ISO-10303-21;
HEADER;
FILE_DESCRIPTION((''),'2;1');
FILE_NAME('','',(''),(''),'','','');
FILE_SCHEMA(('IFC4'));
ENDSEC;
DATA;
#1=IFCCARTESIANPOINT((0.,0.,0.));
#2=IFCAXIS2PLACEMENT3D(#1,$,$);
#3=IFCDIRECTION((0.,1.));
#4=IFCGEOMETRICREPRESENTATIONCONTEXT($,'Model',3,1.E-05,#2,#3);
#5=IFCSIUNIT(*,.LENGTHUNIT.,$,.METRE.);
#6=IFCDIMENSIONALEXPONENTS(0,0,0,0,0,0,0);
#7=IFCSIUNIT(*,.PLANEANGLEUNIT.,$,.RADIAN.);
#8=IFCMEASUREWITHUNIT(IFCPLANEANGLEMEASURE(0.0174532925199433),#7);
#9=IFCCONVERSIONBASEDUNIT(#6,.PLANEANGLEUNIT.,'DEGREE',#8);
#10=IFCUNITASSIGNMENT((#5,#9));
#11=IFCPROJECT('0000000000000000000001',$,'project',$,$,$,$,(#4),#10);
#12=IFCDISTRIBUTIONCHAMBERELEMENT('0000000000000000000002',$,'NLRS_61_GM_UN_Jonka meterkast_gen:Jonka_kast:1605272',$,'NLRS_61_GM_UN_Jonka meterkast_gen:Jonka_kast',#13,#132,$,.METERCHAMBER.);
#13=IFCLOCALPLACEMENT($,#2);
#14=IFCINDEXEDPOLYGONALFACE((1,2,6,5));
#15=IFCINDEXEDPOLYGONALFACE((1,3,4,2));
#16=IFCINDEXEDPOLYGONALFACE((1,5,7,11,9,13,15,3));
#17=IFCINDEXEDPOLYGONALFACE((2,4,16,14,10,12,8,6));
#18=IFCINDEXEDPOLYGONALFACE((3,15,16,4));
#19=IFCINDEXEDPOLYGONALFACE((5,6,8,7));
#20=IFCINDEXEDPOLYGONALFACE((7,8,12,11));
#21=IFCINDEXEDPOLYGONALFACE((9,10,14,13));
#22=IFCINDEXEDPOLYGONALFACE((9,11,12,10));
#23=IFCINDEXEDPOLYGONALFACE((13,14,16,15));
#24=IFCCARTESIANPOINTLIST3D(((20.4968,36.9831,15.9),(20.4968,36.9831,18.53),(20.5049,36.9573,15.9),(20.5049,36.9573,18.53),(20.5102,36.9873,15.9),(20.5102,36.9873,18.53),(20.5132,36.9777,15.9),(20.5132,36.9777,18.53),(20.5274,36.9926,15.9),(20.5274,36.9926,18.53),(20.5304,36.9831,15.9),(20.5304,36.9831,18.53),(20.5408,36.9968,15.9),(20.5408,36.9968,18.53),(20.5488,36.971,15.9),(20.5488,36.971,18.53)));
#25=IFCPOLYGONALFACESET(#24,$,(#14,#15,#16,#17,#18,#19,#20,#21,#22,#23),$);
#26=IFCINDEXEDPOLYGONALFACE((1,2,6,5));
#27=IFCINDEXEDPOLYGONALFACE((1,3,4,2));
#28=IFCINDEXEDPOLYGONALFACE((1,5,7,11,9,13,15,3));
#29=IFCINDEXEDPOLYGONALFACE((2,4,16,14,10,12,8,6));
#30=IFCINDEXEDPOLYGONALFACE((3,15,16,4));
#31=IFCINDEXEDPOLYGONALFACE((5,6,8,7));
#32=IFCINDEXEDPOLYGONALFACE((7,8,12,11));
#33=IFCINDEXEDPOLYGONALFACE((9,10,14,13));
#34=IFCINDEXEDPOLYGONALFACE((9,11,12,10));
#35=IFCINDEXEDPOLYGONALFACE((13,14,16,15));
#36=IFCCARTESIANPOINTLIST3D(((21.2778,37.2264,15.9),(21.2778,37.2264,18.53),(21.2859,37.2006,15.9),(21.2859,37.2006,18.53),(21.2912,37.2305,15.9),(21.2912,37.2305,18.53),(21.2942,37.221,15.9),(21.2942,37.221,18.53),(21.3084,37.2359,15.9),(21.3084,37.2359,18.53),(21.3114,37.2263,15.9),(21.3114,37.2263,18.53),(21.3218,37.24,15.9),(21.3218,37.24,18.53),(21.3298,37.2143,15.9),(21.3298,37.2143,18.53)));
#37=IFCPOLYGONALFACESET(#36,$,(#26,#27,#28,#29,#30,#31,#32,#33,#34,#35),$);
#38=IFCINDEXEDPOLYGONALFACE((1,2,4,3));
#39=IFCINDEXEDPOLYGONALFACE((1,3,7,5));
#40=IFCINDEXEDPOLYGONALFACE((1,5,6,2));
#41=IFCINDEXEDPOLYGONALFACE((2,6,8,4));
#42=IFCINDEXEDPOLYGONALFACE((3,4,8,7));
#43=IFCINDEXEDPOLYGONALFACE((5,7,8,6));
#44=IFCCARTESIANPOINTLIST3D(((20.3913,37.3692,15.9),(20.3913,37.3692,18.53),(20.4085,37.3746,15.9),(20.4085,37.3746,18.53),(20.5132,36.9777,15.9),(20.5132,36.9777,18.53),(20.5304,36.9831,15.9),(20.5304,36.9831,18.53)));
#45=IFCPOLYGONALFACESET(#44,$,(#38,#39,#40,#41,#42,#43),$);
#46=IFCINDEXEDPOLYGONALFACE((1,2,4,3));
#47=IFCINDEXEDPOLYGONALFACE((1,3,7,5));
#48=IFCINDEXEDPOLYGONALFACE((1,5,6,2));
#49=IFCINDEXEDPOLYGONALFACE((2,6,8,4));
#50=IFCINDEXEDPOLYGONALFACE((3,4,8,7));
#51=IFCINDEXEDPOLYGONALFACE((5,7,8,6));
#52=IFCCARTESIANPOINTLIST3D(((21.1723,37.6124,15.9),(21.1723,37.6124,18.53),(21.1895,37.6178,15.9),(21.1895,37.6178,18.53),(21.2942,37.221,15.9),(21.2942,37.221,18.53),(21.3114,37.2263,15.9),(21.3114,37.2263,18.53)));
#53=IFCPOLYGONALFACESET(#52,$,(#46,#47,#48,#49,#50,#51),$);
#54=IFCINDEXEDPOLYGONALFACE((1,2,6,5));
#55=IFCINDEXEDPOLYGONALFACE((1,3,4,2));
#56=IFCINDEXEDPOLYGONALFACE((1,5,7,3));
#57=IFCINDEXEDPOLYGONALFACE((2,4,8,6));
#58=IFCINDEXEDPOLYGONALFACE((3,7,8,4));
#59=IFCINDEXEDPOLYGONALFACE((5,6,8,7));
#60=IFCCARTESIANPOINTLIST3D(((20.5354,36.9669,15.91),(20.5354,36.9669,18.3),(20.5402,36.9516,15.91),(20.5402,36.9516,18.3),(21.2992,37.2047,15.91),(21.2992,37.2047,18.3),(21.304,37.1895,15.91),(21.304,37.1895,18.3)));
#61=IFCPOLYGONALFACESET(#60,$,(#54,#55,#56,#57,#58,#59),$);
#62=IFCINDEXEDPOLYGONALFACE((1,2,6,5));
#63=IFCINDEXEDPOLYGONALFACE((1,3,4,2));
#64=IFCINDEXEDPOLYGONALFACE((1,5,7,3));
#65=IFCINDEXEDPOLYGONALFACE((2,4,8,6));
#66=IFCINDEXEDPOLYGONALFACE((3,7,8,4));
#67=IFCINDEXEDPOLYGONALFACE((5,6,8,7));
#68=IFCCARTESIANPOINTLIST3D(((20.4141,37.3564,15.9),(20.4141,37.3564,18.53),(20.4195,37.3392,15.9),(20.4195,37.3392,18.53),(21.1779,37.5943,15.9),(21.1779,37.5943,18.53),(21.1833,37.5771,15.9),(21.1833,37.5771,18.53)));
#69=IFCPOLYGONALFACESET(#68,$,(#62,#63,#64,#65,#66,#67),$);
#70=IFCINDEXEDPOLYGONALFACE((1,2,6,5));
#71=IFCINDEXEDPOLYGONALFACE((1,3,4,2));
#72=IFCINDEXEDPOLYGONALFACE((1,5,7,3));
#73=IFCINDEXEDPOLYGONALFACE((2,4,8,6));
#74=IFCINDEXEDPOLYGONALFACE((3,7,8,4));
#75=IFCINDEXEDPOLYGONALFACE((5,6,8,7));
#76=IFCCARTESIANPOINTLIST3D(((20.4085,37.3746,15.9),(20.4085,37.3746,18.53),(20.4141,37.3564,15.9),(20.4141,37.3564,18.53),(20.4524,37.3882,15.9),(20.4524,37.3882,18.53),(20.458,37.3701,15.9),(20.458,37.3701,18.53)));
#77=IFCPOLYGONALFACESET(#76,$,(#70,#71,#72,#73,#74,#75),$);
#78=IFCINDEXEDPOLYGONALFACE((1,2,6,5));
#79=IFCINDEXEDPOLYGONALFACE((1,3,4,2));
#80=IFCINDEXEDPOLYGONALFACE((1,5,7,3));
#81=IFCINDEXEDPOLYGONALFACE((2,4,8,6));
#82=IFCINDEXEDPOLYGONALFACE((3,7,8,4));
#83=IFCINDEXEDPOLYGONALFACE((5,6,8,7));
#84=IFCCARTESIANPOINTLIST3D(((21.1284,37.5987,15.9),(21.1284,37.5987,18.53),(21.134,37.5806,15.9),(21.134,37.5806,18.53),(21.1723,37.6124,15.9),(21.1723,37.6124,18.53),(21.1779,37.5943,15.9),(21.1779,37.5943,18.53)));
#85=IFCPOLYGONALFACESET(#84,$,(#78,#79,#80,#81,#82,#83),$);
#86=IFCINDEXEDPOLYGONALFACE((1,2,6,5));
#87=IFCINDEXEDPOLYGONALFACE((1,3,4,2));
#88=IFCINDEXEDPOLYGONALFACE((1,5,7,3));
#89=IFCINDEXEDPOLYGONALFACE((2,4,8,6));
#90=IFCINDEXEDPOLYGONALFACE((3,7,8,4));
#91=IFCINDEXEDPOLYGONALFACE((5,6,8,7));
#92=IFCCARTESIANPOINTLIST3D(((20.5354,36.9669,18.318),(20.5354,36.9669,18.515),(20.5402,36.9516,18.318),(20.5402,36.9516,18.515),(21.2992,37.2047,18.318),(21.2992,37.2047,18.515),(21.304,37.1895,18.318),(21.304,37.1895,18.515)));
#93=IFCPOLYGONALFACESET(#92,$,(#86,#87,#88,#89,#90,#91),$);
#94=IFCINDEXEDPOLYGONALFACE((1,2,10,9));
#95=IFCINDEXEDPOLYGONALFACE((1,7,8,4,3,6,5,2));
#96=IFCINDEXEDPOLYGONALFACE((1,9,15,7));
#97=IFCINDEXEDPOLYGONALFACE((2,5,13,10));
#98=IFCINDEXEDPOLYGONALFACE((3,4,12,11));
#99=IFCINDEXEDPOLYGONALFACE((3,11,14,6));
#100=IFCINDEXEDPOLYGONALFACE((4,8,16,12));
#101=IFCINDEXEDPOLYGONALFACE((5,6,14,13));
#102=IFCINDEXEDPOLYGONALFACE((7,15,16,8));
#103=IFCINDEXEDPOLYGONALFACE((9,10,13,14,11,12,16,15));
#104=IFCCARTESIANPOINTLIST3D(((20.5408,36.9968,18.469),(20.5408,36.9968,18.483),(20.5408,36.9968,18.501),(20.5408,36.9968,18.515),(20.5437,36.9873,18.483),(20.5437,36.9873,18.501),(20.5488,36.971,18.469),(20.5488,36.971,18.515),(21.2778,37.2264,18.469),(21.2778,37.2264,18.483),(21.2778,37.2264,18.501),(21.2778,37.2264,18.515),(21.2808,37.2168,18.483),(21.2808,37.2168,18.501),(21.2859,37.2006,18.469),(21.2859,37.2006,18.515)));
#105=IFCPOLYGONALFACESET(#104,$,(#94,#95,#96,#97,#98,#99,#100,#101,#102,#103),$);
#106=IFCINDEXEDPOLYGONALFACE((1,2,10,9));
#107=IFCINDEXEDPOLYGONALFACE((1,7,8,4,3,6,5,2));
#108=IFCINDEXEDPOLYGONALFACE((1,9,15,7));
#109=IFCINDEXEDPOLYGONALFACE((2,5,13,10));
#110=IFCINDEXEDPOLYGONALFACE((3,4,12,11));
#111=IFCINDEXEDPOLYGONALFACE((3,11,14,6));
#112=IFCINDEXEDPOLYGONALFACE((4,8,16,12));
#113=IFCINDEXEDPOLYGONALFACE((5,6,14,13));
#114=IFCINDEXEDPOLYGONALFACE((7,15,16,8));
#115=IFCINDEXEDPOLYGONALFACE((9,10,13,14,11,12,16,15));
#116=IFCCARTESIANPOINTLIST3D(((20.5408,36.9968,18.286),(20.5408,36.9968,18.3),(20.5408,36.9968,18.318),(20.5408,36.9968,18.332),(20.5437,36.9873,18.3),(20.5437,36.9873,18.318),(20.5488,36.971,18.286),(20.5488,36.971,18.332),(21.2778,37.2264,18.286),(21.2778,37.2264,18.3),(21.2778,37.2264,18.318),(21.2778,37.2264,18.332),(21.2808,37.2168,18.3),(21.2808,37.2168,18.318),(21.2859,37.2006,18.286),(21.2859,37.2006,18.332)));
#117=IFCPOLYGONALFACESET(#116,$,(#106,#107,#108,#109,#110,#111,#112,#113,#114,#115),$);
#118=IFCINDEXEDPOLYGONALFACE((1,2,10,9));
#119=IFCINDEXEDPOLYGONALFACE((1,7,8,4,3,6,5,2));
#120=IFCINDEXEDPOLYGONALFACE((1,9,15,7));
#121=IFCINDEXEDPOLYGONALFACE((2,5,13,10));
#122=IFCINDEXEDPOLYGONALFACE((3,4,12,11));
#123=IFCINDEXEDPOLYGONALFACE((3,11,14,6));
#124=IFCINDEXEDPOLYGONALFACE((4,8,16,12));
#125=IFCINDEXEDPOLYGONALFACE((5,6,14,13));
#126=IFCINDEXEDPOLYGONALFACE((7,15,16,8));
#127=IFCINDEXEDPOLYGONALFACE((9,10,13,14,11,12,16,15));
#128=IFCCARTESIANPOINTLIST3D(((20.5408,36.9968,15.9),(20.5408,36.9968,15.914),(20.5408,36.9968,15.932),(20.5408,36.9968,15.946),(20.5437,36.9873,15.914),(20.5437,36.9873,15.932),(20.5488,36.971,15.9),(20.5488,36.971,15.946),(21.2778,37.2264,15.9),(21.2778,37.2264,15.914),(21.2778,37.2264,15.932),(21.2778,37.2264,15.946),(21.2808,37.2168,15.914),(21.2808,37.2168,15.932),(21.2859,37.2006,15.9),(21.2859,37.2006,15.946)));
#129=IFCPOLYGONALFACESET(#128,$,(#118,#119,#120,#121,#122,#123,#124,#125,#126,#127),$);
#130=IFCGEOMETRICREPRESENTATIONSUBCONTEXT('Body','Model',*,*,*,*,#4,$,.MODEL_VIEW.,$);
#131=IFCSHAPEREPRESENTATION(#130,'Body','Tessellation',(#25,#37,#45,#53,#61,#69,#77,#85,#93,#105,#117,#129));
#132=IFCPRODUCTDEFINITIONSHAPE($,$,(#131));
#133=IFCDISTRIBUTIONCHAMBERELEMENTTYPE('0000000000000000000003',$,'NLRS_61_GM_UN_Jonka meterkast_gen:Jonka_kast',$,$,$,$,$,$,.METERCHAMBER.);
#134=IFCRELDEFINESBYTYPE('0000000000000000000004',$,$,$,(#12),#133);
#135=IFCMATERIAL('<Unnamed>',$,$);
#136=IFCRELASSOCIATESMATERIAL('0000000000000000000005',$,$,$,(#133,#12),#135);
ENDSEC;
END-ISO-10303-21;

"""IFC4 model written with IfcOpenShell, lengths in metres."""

from ifc_helpers import new_model, entity, si_unit, converted_unit, direction, frame, origin, place, context, subcontext, project, indexed_curve, outline, extrude, source, transform, mapped, material, type_object, type_shapes, element, save


model = new_model("IFC4")

# Units and contexts
model_context = context("Model", 3, precision=1e-05, world=origin(), true_north=direction((0.0, 1.0)))
body_context = subcontext(model_context, "Body", "Model", "MODEL_VIEW")
ifc_project = project(units=[si_unit("LENGTHUNIT", "METRE"), converted_unit("PLANEANGLEUNIT", "DEGREE", entity("IfcPlaneAngleMeasure", 0.0174532925199433), si_unit("PLANEANGLEUNIT", "RADIAN"), dimensions=[0, 0, 0, 0, 0, 0, 0])], contexts=[model_context])

# Distribution chamber element
ifc_material = material(Name="<Unnamed>")
distribution_chamber_element_type = type_object("IfcDistributionChamberElementType", Name="NLRS_61_GM_UN_Jonka meterkast_gen:Jonka_kast", PredefinedType="METERCHAMBER", material=ifc_material)
shared_shape_1 = source(origin(), body_context, "Body", "SweptSolid", [
    extrude(outline(indexed_curve([(-0.0093, -0.023), (0.0178, -0.023), (0.0178, 0.023), (-0.0093, 0.023), (-0.0093, 0.009), (0.0007, 0.009), (0.0007, -0.009), (-0.0093, -0.009), (-0.0093, -0.023)], self_intersect=False)), frame((-0.409, -0.4092, 0.0), z_axis=(0.0, 0.0, 1.0), x_axis=(0.0, -1.0, 0.0)), (0.0, 0.0, 1.0), 2.63),
    extrude(outline(indexed_curve([(-0.0093, -0.023), (0.0178, -0.023), (0.0178, 0.023), (-0.0093, 0.023), (-0.0093, 0.009), (0.0007, 0.009), (0.0007, -0.009), (-0.0093, -0.009), (-0.0093, -0.023)], self_intersect=False)), frame((0.409, -0.4092, 0.0), z_axis=(0.0, 0.0, 1.0), x_axis=(0.0, -1.0, 0.0)), (0.0, 0.0, 1.0), 2.63),
    extrude(outline(indexed_curve([(-0.205, -0.009), (0.205, -0.009), (0.205, 0.009), (-0.205, 0.009), (-0.205, -0.009)], self_intersect=False)), frame((-0.409, -0.205, 0.0), z_axis=(0.0, 0.0, 1.0), x_axis=(0.0, -1.0, 0.0)), (0.0, 0.0, 1.0), 2.63),
    extrude(outline(indexed_curve([(-0.205, -0.009), (0.205, -0.009), (0.205, 0.009), (-0.205, 0.009), (-0.205, -0.009)], self_intersect=False)), frame((0.409, -0.205, 0.0), z_axis=(0.0, 0.0, 1.0), x_axis=(0.0, -1.0, 0.0)), (0.0, 0.0, 1.0), 2.63),
    extrude(outline(indexed_curve([(-0.4, -0.008), (0.4, -0.008), (0.4, 0.008), (-0.4, 0.008), (-0.4, -0.008)], self_intersect=False)), frame((0.0, -0.435, 0.01), z_axis=(0.0, 0.0, 1.0), x_axis=(-1.0, 0.0, 0.0)), (0.0, 0.0, 1.0), 2.39),
    extrude(outline(indexed_curve([(-0.4, -0.009), (0.4, -0.009), (0.4, 0.009), (-0.4, 0.009), (-0.4, -0.009)], self_intersect=False)), frame((0.0, -0.028, 0.0), z_axis=(0.0, 0.0, 1.0), x_axis=(-1.0, 0.0, 0.0)), (0.0, 0.0, 1.0), 2.63),
    extrude(outline(indexed_curve([(-0.023, -0.0095), (0.023, -0.0095), (0.023, 0.0095), (-0.023, 0.0095), (-0.023, -0.0095)], self_intersect=False)), frame((-0.377, -0.0095, 0.0), z_axis=(0.0, 0.0, 1.0), x_axis=(-1.0, 0.0, 0.0)), (0.0, 0.0, 1.0), 2.63),
    extrude(outline(indexed_curve([(-0.023, -0.0095), (0.023, -0.0095), (0.023, 0.0095), (-0.023, 0.0095), (-0.023, -0.0095)], self_intersect=False)), frame((0.377, -0.0095, 0.0), z_axis=(0.0, 0.0, 1.0), x_axis=(-1.0, 0.0, 0.0)), (0.0, 0.0, 1.0), 2.63),
    extrude(outline(indexed_curve([(-0.4, -0.008), (0.4, -0.008), (0.4, 0.008), (-0.4, 0.008), (-0.4, -0.008)], self_intersect=False)), frame((0.0, -0.435, 2.418), z_axis=(0.0, 0.0, 1.0), x_axis=(-1.0, 0.0, 0.0)), (0.0, 0.0, 1.0), 0.197),
    extrude(outline(indexed_curve([(-0.023, -0.0178), (0.023, -0.0178), (0.023, 0.0093), (0.009, 0.0093), (0.009, -0.0007), (-0.009, -0.0007), (-0.009, 0.0093), (-0.023, 0.0093), (-0.023, -0.0178)], self_intersect=False)), frame((-0.386, -0.4092, 2.592), z_axis=(1.0, 0.0, 0.0), x_axis=(0.0, 0.0, -1.0)), (0.0, 0.0, 1.0), 0.772),
    extrude(outline(indexed_curve([(-0.023, -0.0178), (0.023, -0.0178), (0.023, 0.0093), (0.009, 0.0093), (0.009, -0.0007), (-0.009, -0.0007), (-0.009, 0.0093), (-0.023, 0.0093), (-0.023, -0.0178)], self_intersect=False)), frame((-0.386, -0.4092, 2.409), z_axis=(1.0, 0.0, 0.0), x_axis=(0.0, 0.0, -1.0)), (0.0, 0.0, 1.0), 0.772),
    extrude(outline(indexed_curve([(-0.023, -0.0178), (0.023, -0.0178), (0.023, 0.0093), (0.009, 0.0093), (0.009, -0.0007), (-0.009, -0.0007), (-0.009, 0.0093), (-0.023, 0.0093), (-0.023, -0.0178)], self_intersect=False)), frame((-0.386, -0.4092, 0.023), z_axis=(1.0, 0.0, 0.0), x_axis=(0.0, 0.0, -1.0)), (0.0, 0.0, 1.0), 0.772),
])
type_shapes(distribution_chamber_element_type, [shared_shape_1])
placement_1 = place(None, frame((13.1348, 11.9886, 0.0), z_axis=(0.0, 0.0, 1.0), x_axis=(0.954771, 0.297342, 0.0)))
placement_2 = place(placement_1, origin())
placement_3 = place(placement_2, frame((0.0, 0.0, 15.9)))
placement_4 = place(placement_3, origin())
distribution_chamber_element_1_placement = place(placement_4, frame((14.893, 22.075, 0.0)))
element("IfcDistributionChamberElement", 1, at=distribution_chamber_element_1_placement, type_object=distribution_chamber_element_type, material=ifc_material, Name="NLRS_61_GM_UN_Jonka meterkast_gen:Jonka_kast:1605272", ObjectType="NLRS_61_GM_UN_Jonka meterkast_gen:Jonka_kast", PredefinedType="METERCHAMBER", context=body_context, shape_type="MappedRepresentation", body=[
    mapped(shared_shape_1, transform((0.0, 0.0, 0.0), scale=1.0)),
])

save(model, "model.ifc")
